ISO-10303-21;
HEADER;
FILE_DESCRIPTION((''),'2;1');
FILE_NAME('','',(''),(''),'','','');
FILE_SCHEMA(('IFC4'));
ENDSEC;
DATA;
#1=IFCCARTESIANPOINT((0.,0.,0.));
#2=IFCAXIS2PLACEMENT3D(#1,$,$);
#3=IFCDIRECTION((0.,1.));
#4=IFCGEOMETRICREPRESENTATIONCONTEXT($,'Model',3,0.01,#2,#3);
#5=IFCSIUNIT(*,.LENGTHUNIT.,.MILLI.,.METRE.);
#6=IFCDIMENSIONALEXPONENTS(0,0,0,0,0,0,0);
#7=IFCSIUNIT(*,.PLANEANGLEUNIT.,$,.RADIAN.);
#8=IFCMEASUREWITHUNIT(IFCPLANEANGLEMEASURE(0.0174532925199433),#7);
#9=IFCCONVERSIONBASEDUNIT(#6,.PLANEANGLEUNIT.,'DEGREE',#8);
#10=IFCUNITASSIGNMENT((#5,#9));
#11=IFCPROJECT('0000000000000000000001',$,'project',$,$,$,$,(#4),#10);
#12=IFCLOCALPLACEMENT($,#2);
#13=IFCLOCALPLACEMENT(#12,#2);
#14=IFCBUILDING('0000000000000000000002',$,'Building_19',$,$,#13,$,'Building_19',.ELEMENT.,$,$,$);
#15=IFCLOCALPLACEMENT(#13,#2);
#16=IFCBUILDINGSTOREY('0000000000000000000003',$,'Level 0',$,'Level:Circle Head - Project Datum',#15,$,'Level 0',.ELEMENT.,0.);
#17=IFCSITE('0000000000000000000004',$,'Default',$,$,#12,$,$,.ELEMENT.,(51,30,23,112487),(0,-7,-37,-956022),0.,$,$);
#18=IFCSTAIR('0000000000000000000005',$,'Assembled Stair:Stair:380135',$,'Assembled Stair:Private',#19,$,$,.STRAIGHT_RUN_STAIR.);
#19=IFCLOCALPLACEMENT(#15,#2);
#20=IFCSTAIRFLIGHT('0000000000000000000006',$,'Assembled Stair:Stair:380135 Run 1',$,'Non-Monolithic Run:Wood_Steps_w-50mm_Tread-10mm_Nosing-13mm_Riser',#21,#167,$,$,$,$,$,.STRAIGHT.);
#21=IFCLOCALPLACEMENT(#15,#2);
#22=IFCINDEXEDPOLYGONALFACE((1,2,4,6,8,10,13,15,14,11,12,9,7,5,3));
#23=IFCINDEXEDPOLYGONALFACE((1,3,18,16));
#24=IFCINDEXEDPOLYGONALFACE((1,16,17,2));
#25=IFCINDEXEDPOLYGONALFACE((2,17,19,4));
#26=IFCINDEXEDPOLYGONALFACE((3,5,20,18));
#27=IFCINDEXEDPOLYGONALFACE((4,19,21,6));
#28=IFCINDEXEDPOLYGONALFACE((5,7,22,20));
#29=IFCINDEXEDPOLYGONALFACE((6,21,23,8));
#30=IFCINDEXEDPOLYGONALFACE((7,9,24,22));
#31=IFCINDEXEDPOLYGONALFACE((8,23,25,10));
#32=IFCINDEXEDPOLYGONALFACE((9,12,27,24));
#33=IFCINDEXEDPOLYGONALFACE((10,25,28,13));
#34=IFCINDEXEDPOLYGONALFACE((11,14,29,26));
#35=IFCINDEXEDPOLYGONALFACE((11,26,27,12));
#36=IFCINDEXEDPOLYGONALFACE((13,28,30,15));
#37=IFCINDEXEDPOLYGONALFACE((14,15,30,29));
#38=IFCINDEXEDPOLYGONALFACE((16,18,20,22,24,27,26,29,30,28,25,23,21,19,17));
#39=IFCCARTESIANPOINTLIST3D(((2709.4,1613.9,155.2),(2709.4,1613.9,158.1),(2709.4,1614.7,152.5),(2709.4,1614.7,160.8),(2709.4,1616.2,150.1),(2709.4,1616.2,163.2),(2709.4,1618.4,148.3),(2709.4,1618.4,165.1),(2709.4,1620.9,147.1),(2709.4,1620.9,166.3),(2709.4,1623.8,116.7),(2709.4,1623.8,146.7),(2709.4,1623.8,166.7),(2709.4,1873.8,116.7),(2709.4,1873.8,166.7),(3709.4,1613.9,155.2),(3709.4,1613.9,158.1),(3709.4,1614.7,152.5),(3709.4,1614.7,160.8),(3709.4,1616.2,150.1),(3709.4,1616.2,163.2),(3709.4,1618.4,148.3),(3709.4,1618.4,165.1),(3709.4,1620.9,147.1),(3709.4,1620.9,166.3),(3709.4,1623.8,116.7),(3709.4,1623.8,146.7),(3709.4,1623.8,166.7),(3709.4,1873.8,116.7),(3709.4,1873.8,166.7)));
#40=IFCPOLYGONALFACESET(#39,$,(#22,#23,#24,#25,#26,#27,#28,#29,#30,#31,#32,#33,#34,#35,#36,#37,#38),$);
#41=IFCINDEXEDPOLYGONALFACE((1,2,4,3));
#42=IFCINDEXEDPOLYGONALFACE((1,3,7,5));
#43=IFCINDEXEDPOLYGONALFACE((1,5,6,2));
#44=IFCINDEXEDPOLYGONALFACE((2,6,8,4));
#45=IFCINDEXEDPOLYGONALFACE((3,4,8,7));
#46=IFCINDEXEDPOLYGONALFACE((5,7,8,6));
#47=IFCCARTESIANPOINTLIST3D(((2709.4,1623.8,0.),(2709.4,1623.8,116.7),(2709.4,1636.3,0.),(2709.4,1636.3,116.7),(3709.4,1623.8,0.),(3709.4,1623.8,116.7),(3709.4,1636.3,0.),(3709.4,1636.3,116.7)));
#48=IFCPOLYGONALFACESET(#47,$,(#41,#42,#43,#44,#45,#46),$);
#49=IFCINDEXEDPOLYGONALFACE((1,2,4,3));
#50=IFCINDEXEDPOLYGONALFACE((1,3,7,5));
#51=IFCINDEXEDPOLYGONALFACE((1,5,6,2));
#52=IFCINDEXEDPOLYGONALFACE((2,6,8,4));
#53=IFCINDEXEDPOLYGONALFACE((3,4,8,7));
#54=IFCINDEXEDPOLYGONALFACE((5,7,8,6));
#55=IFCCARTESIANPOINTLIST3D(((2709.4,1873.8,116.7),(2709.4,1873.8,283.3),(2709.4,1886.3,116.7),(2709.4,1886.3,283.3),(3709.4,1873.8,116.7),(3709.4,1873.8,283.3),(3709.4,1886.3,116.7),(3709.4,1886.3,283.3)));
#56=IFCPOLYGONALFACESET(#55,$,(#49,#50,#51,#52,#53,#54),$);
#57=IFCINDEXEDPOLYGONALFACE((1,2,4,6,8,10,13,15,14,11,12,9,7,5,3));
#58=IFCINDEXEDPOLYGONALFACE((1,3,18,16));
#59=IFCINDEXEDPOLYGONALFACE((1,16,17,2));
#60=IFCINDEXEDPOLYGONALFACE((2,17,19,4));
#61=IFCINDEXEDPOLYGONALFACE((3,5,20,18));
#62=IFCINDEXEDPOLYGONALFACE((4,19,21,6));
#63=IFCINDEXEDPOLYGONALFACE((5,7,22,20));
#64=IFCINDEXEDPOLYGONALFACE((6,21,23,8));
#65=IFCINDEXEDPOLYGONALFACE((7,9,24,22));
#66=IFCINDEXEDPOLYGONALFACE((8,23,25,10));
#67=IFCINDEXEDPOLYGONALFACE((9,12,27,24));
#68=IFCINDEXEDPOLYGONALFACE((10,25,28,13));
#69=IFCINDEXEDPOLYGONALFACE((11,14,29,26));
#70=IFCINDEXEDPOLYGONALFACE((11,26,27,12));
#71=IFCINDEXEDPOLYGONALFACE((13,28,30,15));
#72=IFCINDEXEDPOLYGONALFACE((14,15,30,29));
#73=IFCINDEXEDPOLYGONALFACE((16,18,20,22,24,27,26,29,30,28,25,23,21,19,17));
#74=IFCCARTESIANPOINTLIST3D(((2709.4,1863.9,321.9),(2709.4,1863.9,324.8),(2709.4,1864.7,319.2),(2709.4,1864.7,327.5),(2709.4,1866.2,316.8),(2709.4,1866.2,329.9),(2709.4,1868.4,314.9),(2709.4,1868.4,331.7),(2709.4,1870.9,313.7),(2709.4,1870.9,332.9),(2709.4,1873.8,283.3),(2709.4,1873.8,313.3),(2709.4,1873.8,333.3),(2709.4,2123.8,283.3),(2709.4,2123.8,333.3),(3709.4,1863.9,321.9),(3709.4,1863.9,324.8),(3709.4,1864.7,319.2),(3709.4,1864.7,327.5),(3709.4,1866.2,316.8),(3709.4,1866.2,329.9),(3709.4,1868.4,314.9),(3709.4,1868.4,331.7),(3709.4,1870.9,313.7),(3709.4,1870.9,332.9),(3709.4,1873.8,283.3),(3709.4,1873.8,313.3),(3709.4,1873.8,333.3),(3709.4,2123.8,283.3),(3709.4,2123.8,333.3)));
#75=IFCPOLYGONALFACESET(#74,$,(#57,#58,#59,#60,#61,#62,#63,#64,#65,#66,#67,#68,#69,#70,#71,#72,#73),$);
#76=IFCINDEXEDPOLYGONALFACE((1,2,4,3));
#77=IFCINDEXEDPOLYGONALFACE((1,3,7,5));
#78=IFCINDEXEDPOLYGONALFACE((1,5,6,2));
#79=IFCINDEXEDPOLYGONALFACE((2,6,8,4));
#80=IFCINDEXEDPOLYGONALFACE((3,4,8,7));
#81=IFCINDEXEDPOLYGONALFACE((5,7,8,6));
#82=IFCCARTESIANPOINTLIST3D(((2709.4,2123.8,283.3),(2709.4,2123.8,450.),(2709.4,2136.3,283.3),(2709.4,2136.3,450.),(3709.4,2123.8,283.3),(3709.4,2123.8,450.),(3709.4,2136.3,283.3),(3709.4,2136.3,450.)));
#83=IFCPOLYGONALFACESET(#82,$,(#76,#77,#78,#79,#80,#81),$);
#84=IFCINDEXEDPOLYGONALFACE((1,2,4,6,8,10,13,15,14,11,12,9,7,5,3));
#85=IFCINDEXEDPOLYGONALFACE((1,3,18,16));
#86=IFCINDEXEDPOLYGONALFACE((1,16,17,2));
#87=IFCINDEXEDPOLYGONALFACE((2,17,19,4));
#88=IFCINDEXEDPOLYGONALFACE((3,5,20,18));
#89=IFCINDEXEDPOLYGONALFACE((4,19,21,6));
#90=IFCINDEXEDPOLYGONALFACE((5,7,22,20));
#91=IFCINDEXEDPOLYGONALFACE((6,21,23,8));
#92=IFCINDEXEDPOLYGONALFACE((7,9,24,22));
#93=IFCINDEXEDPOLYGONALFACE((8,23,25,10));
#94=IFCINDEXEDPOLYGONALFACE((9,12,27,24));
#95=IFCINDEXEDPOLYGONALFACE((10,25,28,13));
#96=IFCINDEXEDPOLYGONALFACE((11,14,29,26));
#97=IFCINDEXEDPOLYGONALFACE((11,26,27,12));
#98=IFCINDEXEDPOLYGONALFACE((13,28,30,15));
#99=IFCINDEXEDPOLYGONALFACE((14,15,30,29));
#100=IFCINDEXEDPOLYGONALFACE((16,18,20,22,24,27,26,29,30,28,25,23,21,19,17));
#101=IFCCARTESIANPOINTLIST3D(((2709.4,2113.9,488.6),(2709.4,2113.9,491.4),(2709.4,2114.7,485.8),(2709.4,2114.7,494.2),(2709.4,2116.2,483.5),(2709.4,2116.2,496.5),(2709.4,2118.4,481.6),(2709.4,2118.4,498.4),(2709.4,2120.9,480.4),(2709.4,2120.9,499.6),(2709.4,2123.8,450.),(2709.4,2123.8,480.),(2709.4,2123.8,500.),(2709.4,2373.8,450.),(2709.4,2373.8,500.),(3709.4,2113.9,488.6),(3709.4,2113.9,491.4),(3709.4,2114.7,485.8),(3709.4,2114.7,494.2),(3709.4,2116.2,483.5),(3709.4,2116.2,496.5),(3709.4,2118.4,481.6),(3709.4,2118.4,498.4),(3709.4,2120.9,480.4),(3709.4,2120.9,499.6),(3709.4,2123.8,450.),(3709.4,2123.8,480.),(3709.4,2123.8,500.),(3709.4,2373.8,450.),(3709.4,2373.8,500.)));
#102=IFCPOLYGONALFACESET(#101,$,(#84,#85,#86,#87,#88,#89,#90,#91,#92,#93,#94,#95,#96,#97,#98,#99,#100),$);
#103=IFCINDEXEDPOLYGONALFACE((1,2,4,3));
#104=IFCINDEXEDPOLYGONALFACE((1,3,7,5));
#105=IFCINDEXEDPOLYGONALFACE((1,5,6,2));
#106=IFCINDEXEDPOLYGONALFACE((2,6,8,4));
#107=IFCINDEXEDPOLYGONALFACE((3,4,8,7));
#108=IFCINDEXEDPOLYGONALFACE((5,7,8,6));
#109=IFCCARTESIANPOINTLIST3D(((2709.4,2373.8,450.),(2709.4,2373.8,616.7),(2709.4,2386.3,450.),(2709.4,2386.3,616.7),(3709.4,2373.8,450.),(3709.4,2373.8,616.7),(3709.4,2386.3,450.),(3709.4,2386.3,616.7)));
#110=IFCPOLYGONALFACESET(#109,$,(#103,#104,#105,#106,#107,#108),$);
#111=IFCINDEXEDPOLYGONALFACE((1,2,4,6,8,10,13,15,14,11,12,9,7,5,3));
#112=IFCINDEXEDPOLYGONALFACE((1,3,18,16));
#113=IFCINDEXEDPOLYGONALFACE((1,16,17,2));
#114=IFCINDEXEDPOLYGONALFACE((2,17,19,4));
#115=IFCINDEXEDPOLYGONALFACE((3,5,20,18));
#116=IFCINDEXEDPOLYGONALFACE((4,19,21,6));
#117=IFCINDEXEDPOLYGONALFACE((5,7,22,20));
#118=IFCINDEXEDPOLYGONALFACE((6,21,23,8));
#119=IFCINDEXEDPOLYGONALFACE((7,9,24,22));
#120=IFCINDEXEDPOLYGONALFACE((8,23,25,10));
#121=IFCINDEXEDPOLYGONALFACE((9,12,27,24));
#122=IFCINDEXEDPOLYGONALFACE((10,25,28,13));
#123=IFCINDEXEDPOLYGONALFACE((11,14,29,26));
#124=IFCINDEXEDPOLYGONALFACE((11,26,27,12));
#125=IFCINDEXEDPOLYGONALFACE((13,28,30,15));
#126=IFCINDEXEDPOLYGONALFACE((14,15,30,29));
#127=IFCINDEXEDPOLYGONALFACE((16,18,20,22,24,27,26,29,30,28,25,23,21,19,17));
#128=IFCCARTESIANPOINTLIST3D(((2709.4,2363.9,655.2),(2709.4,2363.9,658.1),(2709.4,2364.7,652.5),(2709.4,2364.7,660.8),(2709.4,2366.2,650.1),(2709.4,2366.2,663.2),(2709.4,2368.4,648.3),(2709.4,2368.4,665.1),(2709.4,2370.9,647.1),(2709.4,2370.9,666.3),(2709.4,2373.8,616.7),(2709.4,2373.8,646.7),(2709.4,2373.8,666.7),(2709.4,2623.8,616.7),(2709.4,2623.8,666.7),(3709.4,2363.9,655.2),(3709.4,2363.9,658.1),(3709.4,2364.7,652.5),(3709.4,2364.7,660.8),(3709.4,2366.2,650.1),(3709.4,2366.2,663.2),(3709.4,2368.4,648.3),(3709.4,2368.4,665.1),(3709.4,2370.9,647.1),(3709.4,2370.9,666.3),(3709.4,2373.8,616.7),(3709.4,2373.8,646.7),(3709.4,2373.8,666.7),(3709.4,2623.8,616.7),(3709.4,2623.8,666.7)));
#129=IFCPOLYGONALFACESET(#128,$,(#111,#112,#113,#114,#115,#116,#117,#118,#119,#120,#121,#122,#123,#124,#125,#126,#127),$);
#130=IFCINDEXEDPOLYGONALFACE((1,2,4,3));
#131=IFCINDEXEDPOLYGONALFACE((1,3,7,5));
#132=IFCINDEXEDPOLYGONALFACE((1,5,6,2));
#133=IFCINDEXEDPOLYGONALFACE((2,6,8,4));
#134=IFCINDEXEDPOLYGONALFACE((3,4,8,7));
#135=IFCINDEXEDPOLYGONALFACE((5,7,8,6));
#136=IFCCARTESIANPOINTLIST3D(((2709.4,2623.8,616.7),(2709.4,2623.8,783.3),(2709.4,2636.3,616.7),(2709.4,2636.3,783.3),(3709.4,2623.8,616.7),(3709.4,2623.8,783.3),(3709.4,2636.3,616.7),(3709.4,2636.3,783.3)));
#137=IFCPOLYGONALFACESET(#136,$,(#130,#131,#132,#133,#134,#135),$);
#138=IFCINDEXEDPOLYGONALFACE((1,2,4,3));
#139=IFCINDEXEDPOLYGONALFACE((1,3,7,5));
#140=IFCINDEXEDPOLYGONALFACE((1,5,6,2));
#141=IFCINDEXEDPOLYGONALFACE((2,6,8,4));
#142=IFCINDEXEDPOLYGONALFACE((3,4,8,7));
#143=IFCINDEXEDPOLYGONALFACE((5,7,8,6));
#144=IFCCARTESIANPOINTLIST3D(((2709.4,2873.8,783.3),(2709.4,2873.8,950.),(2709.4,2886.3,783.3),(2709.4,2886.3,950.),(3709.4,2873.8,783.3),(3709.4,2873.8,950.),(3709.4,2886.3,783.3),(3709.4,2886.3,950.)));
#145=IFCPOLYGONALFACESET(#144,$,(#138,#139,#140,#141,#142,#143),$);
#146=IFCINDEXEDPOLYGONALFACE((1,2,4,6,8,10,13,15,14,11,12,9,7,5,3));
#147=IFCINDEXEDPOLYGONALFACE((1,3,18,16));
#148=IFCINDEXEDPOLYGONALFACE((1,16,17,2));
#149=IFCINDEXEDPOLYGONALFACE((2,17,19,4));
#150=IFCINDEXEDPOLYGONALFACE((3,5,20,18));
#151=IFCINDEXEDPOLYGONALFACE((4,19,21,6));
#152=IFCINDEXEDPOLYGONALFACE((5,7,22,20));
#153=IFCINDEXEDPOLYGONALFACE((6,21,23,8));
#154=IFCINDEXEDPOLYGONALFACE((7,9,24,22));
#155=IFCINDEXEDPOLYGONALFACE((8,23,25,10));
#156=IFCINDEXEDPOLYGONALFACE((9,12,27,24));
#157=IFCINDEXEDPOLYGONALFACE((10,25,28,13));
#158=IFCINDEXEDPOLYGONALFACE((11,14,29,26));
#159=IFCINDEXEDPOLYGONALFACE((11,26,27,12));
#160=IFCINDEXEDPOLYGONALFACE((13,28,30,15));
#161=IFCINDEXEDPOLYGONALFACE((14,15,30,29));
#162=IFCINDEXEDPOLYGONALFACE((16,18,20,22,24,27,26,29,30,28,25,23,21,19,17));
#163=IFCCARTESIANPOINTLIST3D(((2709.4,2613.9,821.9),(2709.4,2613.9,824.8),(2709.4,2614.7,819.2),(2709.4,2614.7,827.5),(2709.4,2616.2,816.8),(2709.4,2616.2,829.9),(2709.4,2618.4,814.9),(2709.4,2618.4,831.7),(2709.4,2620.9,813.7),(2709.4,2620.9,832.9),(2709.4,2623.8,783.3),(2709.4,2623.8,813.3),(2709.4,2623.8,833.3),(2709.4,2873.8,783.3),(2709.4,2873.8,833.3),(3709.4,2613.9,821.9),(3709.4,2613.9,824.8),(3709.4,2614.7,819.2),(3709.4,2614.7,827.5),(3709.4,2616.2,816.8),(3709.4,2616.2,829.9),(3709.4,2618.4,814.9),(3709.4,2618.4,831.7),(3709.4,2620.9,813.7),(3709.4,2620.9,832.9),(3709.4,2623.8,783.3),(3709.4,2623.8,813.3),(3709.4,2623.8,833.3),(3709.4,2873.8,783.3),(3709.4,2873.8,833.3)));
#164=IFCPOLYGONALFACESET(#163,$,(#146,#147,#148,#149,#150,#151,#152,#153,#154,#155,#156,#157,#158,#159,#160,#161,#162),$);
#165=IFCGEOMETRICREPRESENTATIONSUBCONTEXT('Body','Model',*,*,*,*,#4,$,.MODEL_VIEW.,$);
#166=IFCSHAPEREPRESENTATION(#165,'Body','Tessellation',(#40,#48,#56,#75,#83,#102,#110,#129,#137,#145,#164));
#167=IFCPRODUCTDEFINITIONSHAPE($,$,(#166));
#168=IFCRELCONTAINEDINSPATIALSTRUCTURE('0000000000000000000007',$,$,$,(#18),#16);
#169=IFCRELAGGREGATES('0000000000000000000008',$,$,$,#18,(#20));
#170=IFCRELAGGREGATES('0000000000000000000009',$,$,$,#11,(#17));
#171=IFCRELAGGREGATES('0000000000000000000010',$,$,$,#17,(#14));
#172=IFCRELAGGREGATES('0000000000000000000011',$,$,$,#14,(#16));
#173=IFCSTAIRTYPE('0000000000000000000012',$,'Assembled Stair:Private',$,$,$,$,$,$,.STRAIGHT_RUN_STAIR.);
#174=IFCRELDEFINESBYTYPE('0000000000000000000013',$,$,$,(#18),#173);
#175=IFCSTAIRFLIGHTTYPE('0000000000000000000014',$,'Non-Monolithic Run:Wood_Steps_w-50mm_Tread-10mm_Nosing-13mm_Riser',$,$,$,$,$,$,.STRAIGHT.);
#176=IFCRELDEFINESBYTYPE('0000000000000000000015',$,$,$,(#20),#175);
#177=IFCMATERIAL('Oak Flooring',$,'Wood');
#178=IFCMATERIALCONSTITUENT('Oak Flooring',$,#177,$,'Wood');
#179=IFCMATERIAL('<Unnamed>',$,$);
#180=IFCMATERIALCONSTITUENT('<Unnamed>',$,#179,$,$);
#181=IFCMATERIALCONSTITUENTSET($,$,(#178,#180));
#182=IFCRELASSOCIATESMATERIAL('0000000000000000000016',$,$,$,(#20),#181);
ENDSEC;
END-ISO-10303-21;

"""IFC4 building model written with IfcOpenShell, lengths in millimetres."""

from ifc_helpers import new_model, entity, si_unit, converted_unit, direction, frame, origin, place, context, subcontext, project, spatial, line, arc, indexed_curve, outline, extrude, material, constituent, constituent_set, type_object, element, aggregate, save


model = new_model("IFC4")

# Units and contexts
model_context = context("Model", 3, precision=0.01, world=origin(), true_north=direction((0.0, 1.0)))
body_context = subcontext(model_context, "Body", "Model", "MODEL_VIEW")
ifc_project = project(units=[si_unit("LENGTHUNIT", "METRE", prefix="MILLI"), converted_unit("PLANEANGLEUNIT", "DEGREE", entity("IfcPlaneAngleMeasure", 0.0174532925199433), si_unit("PLANEANGLEUNIT", "RADIAN"), dimensions=[0, 0, 0, 0, 0, 0, 0])], contexts=[model_context])

# Site, building, storey
site_placement = place(None, origin())
site = spatial("IfcSite", under=ifc_project, at=site_placement, Name="Default", CompositionType="ELEMENT", RefLatitude=(51, 30, 23, 112487), RefLongitude=(0, -7, -37, -956022), RefElevation=0.0)
building_placement = place(site_placement, origin())
building = spatial("IfcBuilding", under=site, at=building_placement, Name="Building_19", LongName="Building_19", CompositionType="ELEMENT")
storey_placement = place(building_placement, origin())
storey = spatial("IfcBuildingStorey", under=building, at=storey_placement, Name="Level 0", ObjectType="Level:Circle Head - Project Datum", LongName="Level 0", CompositionType="ELEMENT", Elevation=0.0)

# Stair
stair_type = type_object("IfcStairType", Name="Assembled Stair:Private", PredefinedType="STRAIGHT_RUN_STAIR")
ifc_material_1 = material(Name="<Unnamed>")
stair_1_placement = place(storey_placement, origin())
stair_1 = element("IfcStair", 1, at=stair_1_placement, inside=storey, type_object=stair_type, Name="Assembled Stair:Stair:380135", ObjectType="Assembled Stair:Private", PredefinedType="STRAIGHT_RUN_STAIR")

# Stair flight
ifc_material_2 = material(Name="Oak Flooring", Category="Wood")
stair_flight_type = type_object("IfcStairFlightType", Name="Non-Monolithic Run:Wood_Steps_w-50mm_Tread-10mm_Nosing-13mm_Riser", PredefinedType="STRAIGHT")
ifc_constituent_1 = constituent(ifc_material_2, Name="Oak Flooring", Category="Wood")
ifc_constituent_2 = constituent(ifc_material_1, Name="<Unnamed>")
ifc_constituent_set_1 = constituent_set(constituents=[ifc_constituent_1, ifc_constituent_2])
stair_flight_1_placement = place(stair_1_placement, origin())
stair_flight_1 = element("IfcStairFlight", 2, at=stair_flight_1_placement, type_object=stair_flight_type, material=ifc_constituent_set_1, Name="Assembled Stair:Stair:380135 Run 1", ObjectType="Non-Monolithic Run:Wood_Steps_w-50mm_Tread-10mm_Nosing-13mm_Riser", PredefinedType="STRAIGHT", context=body_context, shape_type="SweptSolid", body=[
    extrude(outline(indexed_curve([(-100.0, 24.0), (-110.0, 14.0), (-100.0, 4.0), (-100.0, -26.0), (150.0, -26.0), (150.0, 24.0)], segments=[arc(1, 2, 3), line(3, 4, 5, 6, 1)], self_intersect=False)), frame((2709.4, 1723.8, 142.7), z_axis=(1.0, 0.0, 0.0), x_axis=(0.0, 1.0, 0.0)), (0.0, 0.0, 1.0), 1000.0),
    extrude(outline(indexed_curve([(-500.0, -6.2), (500.0, -6.2), (500.0, 6.3), (-500.0, 6.3), (-500.0, -6.2)], self_intersect=False)), frame((3209.4, 1630.0, 0.0), z_axis=(0.0, 0.0, 1.0), x_axis=(-1.0, 0.0, 0.0)), (0.0, 0.0, 1.0), 116.7),
    extrude(outline(indexed_curve([(-500.0, -6.2), (500.0, -6.2), (500.0, 6.3), (-500.0, 6.3), (-500.0, -6.2)], self_intersect=False)), frame((3209.4, 1880.0, 116.7), z_axis=(0.0, 0.0, 1.0), x_axis=(-1.0, 0.0, 0.0)), (0.0, 0.0, 1.0), 166.7),
    extrude(outline(indexed_curve([(-100.0, 24.0), (-110.0, 14.0), (-100.0, 4.0), (-100.0, -26.0), (150.0, -26.0), (150.0, 24.0)], segments=[arc(1, 2, 3), line(3, 4, 5, 6, 1)], self_intersect=False)), frame((2709.4, 1973.8, 309.3), z_axis=(1.0, 0.0, 0.0), x_axis=(0.0, 1.0, 0.0)), (0.0, 0.0, 1.0), 1000.0),
    extrude(outline(indexed_curve([(-500.0, -6.2), (500.0, -6.2), (500.0, 6.3), (-500.0, 6.3), (-500.0, -6.2)], self_intersect=False)), frame((3209.4, 2130.0, 283.3), z_axis=(0.0, 0.0, 1.0), x_axis=(-1.0, 0.0, 0.0)), (0.0, 0.0, 1.0), 166.7),
    extrude(outline(indexed_curve([(-100.0, 24.0), (-110.0, 14.0), (-100.0, 4.0), (-100.0, -26.0), (150.0, -26.0), (150.0, 24.0)], segments=[arc(1, 2, 3), line(3, 4, 5, 6, 1)], self_intersect=False)), frame((2709.4, 2223.8, 476.0), z_axis=(1.0, 0.0, 0.0), x_axis=(0.0, 1.0, 0.0)), (0.0, 0.0, 1.0), 1000.0),
    extrude(outline(indexed_curve([(-500.0, -6.2), (500.0, -6.2), (500.0, 6.3), (-500.0, 6.3), (-500.0, -6.2)], self_intersect=False)), frame((3209.4, 2380.0, 450.0), z_axis=(0.0, 0.0, 1.0), x_axis=(-1.0, 0.0, 0.0)), (0.0, 0.0, 1.0), 166.7),
    extrude(outline(indexed_curve([(-100.0, 24.0), (-110.0, 14.0), (-100.0, 4.0), (-100.0, -26.0), (150.0, -26.0), (150.0, 24.0)], segments=[arc(1, 2, 3), line(3, 4, 5, 6, 1)], self_intersect=False)), frame((2709.4, 2473.8, 642.7), z_axis=(1.0, 0.0, 0.0), x_axis=(0.0, 1.0, 0.0)), (0.0, 0.0, 1.0), 1000.0),
    extrude(outline(indexed_curve([(-500.0, -6.3), (500.0, -6.3), (500.0, 6.3), (-500.0, 6.3), (-500.0, -6.3)], self_intersect=False)), frame((3209.4, 2630.0, 616.7), z_axis=(0.0, 0.0, 1.0), x_axis=(-1.0, 0.0, 0.0)), (0.0, 0.0, 1.0), 166.7),
    extrude(outline(indexed_curve([(-500.0, -6.3), (500.0, -6.3), (500.0, 6.2), (-500.0, 6.2), (-500.0, -6.3)], self_intersect=False)), frame((3209.4, 2880.0, 783.3), z_axis=(0.0, 0.0, 1.0), x_axis=(-1.0, 0.0, 0.0)), (0.0, 0.0, 1.0), 166.7),
    extrude(outline(indexed_curve([(-100.0, 24.0), (-110.0, 14.0), (-100.0, 4.0), (-100.0, -26.0), (150.0, -26.0), (150.0, 24.0)], segments=[arc(1, 2, 3), line(3, 4, 5, 6, 1)], self_intersect=False)), frame((2709.4, 2723.8, 809.3), z_axis=(1.0, 0.0, 0.0), x_axis=(0.0, 1.0, 0.0)), (0.0, 0.0, 1.0), 1000.0),
])
aggregate(stair_1, [stair_flight_1])

save(model, "model.ifc")
